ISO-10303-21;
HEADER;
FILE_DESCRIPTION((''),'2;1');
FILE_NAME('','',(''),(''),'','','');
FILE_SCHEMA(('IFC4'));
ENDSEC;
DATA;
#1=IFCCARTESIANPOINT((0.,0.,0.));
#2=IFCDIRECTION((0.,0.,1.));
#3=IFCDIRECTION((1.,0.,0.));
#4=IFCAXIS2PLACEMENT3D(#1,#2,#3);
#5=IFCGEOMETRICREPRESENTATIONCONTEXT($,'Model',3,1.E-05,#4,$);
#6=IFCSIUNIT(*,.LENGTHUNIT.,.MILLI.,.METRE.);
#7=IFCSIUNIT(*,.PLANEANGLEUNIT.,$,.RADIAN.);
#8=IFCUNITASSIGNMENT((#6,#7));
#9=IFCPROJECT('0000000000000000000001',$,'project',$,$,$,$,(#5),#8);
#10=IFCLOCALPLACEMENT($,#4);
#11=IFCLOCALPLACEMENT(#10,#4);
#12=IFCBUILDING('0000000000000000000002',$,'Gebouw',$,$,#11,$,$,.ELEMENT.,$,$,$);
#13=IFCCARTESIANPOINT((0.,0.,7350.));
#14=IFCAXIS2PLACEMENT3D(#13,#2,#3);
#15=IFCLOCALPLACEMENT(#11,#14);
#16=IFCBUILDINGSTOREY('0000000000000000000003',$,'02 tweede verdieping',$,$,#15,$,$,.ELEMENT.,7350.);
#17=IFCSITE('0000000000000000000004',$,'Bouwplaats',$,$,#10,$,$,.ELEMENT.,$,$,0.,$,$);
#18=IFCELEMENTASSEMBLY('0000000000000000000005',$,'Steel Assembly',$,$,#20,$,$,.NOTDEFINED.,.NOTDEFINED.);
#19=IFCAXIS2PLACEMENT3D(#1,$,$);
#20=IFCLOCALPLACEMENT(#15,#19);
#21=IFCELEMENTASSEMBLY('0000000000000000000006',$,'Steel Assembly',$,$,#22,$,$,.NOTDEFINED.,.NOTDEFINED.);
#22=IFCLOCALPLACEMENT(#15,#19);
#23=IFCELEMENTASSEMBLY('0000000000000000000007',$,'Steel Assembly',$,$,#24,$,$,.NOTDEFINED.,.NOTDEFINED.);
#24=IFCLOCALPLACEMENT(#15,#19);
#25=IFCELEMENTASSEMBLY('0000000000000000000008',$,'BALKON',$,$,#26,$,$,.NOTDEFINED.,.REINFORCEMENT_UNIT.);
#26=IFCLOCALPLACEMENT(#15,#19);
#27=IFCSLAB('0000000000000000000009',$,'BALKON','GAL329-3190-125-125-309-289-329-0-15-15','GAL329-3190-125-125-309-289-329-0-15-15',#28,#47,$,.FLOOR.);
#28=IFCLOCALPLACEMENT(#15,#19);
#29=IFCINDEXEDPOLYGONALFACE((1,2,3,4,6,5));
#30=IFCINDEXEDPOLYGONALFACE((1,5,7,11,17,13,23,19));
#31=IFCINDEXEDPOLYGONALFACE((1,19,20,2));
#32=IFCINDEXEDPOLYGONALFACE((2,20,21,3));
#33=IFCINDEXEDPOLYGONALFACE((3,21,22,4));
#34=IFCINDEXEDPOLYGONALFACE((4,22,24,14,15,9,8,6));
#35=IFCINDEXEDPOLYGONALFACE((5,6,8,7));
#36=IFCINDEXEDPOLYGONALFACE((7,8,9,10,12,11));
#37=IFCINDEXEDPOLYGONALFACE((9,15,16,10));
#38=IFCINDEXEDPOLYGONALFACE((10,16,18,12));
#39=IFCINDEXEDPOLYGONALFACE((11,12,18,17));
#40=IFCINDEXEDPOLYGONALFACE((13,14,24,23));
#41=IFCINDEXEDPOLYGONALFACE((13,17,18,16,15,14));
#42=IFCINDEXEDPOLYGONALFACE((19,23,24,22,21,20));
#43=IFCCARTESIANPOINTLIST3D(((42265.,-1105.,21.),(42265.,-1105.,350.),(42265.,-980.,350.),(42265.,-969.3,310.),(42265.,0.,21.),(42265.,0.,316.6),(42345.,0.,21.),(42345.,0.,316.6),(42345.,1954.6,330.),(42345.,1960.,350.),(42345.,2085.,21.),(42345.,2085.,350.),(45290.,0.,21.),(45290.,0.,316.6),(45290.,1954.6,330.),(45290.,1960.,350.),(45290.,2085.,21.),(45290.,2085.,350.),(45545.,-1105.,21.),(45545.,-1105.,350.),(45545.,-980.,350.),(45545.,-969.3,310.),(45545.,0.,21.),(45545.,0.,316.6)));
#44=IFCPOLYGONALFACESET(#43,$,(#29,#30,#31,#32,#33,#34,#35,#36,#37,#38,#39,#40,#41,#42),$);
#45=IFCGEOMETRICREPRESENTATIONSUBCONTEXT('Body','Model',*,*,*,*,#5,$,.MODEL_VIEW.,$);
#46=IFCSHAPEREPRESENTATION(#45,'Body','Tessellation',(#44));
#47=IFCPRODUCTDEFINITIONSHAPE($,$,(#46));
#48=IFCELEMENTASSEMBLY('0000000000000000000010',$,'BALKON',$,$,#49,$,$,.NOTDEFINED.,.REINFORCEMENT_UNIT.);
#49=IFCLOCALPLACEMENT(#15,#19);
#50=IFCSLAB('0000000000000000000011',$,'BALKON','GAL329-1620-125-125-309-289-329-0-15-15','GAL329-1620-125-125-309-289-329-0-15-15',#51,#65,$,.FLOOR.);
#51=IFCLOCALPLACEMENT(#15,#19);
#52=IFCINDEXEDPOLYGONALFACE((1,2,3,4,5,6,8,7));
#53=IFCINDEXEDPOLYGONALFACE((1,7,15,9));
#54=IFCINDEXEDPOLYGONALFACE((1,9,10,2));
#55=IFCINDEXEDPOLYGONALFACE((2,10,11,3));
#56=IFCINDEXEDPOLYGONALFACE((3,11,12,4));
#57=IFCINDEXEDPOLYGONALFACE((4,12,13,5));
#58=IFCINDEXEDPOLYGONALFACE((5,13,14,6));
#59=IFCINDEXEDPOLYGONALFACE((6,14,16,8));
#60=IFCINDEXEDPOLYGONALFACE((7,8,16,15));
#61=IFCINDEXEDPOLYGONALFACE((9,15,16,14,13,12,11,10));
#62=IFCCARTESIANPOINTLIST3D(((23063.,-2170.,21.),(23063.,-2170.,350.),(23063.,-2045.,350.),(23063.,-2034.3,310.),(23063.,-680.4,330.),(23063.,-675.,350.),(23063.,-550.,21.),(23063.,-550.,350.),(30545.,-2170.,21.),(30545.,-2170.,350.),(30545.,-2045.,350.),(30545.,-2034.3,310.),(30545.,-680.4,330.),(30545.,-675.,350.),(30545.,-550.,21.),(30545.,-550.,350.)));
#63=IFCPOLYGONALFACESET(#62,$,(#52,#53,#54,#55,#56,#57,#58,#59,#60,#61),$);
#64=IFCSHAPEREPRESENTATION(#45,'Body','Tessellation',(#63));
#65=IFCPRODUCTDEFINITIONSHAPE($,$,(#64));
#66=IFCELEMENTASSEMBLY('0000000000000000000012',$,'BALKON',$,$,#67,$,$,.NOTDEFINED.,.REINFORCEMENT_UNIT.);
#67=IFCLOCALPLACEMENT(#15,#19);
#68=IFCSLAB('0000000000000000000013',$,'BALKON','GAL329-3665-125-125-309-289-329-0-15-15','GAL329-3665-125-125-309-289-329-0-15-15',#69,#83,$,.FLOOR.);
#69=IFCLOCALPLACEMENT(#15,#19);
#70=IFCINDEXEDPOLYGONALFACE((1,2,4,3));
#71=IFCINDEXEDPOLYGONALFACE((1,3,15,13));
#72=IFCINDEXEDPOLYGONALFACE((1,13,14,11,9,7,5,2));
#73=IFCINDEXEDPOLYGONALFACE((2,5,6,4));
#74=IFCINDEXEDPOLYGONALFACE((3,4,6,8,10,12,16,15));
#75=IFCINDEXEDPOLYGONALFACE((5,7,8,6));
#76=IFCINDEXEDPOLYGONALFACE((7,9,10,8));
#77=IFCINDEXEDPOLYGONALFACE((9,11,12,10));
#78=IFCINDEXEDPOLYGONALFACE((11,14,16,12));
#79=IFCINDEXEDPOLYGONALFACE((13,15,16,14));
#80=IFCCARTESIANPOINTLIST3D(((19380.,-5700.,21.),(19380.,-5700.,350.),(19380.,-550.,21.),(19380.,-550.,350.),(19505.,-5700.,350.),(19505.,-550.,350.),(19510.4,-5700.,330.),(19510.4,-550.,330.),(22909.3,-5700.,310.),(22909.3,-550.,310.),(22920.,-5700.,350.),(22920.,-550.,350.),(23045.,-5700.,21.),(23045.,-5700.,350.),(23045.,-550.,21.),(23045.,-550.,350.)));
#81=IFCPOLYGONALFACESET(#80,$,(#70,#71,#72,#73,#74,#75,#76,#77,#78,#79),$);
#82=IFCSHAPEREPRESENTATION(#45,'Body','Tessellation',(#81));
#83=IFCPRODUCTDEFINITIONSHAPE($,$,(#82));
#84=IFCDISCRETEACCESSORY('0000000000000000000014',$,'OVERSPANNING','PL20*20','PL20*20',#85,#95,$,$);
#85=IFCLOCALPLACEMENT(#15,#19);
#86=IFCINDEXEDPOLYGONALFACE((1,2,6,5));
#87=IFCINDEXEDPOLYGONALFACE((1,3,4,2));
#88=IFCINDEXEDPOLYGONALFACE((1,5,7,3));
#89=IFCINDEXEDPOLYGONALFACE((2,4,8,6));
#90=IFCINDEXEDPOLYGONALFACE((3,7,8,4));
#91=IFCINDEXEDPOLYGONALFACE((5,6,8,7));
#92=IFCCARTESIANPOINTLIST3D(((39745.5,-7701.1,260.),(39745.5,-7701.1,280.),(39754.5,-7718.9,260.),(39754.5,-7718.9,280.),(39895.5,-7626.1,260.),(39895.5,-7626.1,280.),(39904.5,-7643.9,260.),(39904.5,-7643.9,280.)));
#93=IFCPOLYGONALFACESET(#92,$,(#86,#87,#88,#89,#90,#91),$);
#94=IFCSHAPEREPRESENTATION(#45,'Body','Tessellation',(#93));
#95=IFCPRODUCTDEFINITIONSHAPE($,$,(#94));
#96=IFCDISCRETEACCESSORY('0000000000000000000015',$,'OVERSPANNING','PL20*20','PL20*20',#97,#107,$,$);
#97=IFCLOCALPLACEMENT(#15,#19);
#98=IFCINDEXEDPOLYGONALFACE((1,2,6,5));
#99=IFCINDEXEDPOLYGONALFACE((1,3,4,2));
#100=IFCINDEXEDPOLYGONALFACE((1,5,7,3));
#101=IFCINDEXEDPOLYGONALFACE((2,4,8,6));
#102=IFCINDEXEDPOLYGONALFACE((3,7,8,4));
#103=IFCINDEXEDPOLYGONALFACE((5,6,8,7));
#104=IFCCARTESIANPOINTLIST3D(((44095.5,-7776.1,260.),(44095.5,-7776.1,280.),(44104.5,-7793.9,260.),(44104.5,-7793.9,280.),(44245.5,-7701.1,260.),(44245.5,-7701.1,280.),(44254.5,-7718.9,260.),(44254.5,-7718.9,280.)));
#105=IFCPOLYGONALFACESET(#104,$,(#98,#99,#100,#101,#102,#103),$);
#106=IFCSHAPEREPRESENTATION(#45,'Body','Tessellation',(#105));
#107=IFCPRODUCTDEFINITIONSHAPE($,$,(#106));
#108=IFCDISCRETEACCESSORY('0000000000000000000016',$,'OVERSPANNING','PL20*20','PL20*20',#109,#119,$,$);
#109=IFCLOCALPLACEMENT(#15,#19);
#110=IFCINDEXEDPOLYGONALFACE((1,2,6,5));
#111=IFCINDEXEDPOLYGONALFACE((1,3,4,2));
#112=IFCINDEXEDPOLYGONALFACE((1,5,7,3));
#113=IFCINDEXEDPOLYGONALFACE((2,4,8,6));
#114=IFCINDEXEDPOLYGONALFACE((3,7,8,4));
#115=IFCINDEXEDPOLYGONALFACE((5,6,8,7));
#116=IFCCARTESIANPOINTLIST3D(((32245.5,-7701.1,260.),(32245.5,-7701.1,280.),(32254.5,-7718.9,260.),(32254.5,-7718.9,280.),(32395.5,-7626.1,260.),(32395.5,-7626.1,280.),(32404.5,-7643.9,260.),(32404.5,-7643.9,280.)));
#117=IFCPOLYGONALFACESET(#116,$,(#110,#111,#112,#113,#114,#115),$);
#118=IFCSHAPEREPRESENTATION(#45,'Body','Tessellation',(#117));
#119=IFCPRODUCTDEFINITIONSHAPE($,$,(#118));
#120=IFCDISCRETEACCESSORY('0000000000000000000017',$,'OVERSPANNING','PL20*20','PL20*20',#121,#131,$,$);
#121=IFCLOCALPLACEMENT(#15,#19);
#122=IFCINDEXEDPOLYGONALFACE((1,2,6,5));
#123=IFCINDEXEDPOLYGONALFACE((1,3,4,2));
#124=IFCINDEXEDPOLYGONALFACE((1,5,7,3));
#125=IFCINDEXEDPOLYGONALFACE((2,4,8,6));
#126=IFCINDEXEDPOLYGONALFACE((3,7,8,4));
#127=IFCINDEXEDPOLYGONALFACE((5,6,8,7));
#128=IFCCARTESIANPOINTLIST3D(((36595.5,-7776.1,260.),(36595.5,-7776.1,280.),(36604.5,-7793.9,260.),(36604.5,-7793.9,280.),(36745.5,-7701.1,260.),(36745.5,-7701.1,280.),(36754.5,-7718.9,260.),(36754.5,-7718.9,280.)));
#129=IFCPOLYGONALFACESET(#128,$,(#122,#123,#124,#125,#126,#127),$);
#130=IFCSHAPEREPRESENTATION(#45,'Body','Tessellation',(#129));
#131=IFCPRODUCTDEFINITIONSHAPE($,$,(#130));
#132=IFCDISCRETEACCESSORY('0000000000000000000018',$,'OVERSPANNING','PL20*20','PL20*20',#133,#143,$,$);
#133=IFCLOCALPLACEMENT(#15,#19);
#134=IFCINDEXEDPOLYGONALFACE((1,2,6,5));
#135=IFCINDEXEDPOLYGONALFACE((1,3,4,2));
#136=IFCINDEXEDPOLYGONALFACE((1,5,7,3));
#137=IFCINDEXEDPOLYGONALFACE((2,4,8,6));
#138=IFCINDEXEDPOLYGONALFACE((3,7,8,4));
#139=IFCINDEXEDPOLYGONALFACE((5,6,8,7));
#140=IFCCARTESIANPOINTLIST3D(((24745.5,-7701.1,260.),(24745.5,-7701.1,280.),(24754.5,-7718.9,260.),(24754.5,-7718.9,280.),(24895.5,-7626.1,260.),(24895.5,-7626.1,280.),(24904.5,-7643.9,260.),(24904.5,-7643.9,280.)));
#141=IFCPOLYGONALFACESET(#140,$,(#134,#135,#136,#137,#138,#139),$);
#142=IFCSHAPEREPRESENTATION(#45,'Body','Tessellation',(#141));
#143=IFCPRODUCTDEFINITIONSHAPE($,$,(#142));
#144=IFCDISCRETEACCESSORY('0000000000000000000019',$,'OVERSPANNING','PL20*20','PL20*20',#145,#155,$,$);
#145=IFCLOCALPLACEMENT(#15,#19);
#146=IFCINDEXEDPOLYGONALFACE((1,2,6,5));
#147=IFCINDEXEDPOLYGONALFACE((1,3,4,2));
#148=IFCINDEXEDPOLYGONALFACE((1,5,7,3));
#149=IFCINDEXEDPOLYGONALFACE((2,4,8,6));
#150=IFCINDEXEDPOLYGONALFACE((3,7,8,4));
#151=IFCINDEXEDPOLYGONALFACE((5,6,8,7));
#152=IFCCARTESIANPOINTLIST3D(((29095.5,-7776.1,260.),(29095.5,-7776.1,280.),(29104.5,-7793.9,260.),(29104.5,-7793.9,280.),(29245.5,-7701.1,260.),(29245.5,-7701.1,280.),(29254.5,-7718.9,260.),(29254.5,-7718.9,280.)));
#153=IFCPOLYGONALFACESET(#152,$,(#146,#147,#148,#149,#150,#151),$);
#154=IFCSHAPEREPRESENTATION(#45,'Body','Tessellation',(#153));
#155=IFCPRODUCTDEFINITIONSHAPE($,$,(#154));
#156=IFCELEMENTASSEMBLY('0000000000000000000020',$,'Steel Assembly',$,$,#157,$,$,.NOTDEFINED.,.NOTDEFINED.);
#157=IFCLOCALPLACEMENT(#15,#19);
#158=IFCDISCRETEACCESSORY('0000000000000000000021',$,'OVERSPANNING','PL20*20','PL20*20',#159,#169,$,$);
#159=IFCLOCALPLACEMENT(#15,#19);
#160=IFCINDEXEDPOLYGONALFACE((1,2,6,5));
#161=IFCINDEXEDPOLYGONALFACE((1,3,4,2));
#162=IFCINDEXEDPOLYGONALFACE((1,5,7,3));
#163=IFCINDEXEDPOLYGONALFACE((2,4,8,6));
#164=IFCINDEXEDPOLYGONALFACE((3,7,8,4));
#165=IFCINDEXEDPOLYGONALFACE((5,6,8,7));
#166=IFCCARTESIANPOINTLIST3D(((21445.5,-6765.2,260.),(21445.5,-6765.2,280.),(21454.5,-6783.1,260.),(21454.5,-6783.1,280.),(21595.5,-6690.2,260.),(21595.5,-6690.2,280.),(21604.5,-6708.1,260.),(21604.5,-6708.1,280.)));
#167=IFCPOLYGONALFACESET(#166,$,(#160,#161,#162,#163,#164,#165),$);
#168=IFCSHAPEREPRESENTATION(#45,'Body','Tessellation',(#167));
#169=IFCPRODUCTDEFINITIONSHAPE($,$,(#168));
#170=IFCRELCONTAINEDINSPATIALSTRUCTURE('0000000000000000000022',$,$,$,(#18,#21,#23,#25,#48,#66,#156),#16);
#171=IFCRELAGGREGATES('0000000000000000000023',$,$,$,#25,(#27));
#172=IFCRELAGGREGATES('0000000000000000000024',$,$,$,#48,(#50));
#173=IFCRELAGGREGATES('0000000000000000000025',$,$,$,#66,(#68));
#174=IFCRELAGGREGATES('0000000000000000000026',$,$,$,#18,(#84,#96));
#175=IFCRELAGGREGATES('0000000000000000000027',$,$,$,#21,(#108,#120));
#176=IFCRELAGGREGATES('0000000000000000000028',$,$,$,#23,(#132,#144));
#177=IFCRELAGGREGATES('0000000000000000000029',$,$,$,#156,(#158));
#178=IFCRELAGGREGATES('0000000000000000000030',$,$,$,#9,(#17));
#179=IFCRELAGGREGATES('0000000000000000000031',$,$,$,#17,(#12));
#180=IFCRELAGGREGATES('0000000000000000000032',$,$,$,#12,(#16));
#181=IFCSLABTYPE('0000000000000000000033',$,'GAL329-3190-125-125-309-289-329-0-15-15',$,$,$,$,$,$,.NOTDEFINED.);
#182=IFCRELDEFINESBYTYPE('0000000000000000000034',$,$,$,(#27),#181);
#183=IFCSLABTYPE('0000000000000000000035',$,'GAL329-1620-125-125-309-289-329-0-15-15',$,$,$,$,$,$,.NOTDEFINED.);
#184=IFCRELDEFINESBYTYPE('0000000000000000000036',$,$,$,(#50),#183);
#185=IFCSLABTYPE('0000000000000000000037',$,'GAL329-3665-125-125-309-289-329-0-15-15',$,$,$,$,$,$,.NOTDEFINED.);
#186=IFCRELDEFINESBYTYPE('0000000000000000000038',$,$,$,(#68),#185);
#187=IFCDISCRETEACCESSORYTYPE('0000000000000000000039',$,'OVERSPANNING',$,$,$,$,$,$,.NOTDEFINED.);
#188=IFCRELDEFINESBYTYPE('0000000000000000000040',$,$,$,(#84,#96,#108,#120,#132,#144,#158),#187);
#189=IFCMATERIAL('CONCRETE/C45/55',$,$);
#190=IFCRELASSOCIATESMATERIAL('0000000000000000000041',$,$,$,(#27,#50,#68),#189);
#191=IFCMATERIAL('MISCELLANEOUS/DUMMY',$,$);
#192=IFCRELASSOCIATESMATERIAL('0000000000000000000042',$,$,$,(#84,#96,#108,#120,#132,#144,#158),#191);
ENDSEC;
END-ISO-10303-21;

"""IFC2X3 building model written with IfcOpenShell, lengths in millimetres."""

from ifc_helpers import new_model, si_unit, frame, origin_with_axes, origin_2d_with_axis, place, context, subcontext, project, spatial, polyline, rectangle, outline, extrude, boolean, material, type_object, element, aggregate, save


model = new_model("IFC2X3")

# Units and contexts
model_context = context("Model", 3, precision=1e-05, world=origin_with_axes())
body_context = subcontext(model_context, "Body", "Model", "MODEL_VIEW")
ifc_project = project(units=[si_unit("LENGTHUNIT", "METRE", prefix="MILLI"), si_unit("PLANEANGLEUNIT", "RADIAN")], contexts=[model_context])

# Site, building, storey
site_placement = place(None, origin_with_axes())
site = spatial("IfcSite", under=ifc_project, at=site_placement, Name="Bouwplaats", CompositionType="ELEMENT", RefElevation=0.0)
building_placement = place(site_placement, origin_with_axes())
building = spatial("IfcBuilding", under=site, at=building_placement, Name="Gebouw", CompositionType="ELEMENT")
storey_placement = place(building_placement, frame((0.0, 0.0, 7350.0), z_axis=(0.0, 0.0, 1.0), x_axis=(1.0, 0.0, 0.0)))
storey = spatial("IfcBuildingStorey", under=building, at=storey_placement, Name="02 tweede verdieping", CompositionType="ELEMENT", Elevation=7350.0)

# Element assemblies
ifc_material_1 = material(Name="MISCELLANEOUS/DUMMY")
assembly_1_placement = place(storey_placement, origin_with_axes())
assembly_1 = element("IfcElementAssembly", 1, at=assembly_1_placement, inside=storey, Name="Steel Assembly", AssemblyPlace="NOTDEFINED", PredefinedType="NOTDEFINED")
assembly_2_placement = place(storey_placement, origin_with_axes())
assembly_2 = element("IfcElementAssembly", 2, at=assembly_2_placement, inside=storey, Name="Steel Assembly", AssemblyPlace="NOTDEFINED", PredefinedType="NOTDEFINED")
assembly_3_placement = place(storey_placement, origin_with_axes())
assembly_3 = element("IfcElementAssembly", 3, at=assembly_3_placement, inside=storey, Name="Steel Assembly", AssemblyPlace="NOTDEFINED", PredefinedType="NOTDEFINED")

# Element assemblies, slabs
ifc_material_2 = material(Name="CONCRETE/C45/55")
slab_type_1 = type_object("IfcSlabType", Name="GAL329-3190-125-125-309-289-329-0-15-15", PredefinedType="NOTDEFINED")
assembly_4_placement = place(storey_placement, origin_with_axes())
assembly_4 = element("IfcElementAssembly", 4, at=assembly_4_placement, inside=storey, Name="BALKON", AssemblyPlace="NOTDEFINED", PredefinedType="REINFORCEMENT_UNIT")
slab_1_placement = place(assembly_4_placement, frame((42265.0, 490.0, 185.5), z_axis=(0.0, 0.0, 1.0), x_axis=(1.0, 0.0, 0.0)))
slab_1 = element("IfcSlab", 5, at=slab_1_placement, type_object=slab_type_1, material=ifc_material_2, Name="BALKON", Description="GAL329-3190-125-125-309-289-329-0-15-15", ObjectType="GAL329-3190-125-125-309-289-329-0-15-15", PredefinedType="FLOOR", context=body_context, shape_type="CSG", body=[
    boolean("DIFFERENCE", boolean("DIFFERENCE", extrude(outline(polyline([(1595.0, -164.5), (-1595.0, -164.5), (-1595.0, 164.5), (-1470.0, 164.5), (-1464.6, 144.5), (1459.3, 124.5), (1470.0, 164.5), (1595.0, 164.5), (1595.0, -164.5)])), frame((3280.0, 0.0, 0.0), z_axis=(-1.0, 0.0, 0.0), x_axis=(0.0, -1.0, 0.0)), (0.0, 0.0, 1.0), 3280.0), extrude(rectangle(XDim=350.0, YDim=255.0, at=origin_2d_with_axis()), frame((3152.5, 1595.0, -10.5), z_axis=(0.0, -1.0, 0.0), x_axis=(0.0, 0.0, -1.0)), (0.0, 0.0, 1.0), 2085.0)), extrude(rectangle(XDim=350.0, YDim=80.0, at=origin_2d_with_axis()), frame((40.0, -490.0, -10.5), z_axis=(0.0, 1.0, 0.0), x_axis=(0.0, 0.0, -1.0)), (0.0, 0.0, 1.0), 2085.0)),
])
aggregate(assembly_4, [slab_1])
assembly_5_placement = place(storey_placement, origin_with_axes())
assembly_5 = element("IfcElementAssembly", 6, at=assembly_5_placement, inside=storey, Name="BALKON", AssemblyPlace="NOTDEFINED", PredefinedType="REINFORCEMENT_UNIT")
slab_type_2 = type_object("IfcSlabType", Name="GAL329-1620-125-125-309-289-329-0-15-15", PredefinedType="NOTDEFINED")
slab_2_placement = place(assembly_5_placement, frame((23063.0, -1360.0, 185.5), z_axis=(0.0, 0.0, 1.0), x_axis=(1.0, 0.0, 0.0)))
slab_2 = element("IfcSlab", 7, at=slab_2_placement, type_object=slab_type_2, material=ifc_material_2, Name="BALKON", Description="GAL329-1620-125-125-309-289-329-0-15-15", ObjectType="GAL329-1620-125-125-309-289-329-0-15-15", PredefinedType="FLOOR", context=body_context, shape_type="SweptSolid", body=[
    extrude(outline(polyline([(810.0, -164.5), (-810.0, -164.5), (-810.0, 164.5), (-685.0, 164.5), (-679.6, 144.5), (674.3, 124.5), (685.0, 164.5), (810.0, 164.5), (810.0, -164.5)])), frame((7482.0, 0.0, 0.0), z_axis=(-1.0, 0.0, 0.0), x_axis=(0.0, -1.0, 0.0)), (0.0, 0.0, 1.0), 7482.0),
])
aggregate(assembly_5, [slab_2])
assembly_6_placement = place(storey_placement, origin_with_axes())
assembly_6 = element("IfcElementAssembly", 8, at=assembly_6_placement, inside=storey, Name="BALKON", AssemblyPlace="NOTDEFINED", PredefinedType="REINFORCEMENT_UNIT")
slab_type_3 = type_object("IfcSlabType", Name="GAL329-3665-125-125-309-289-329-0-15-15", PredefinedType="NOTDEFINED")
slab_3_placement = place(assembly_6_placement, frame((21212.5, -5700.0, 185.5), z_axis=(0.0, 0.0, 1.0), x_axis=(0.0, 1.0, 0.0)))
slab_3 = element("IfcSlab", 9, at=slab_3_placement, type_object=slab_type_3, material=ifc_material_2, Name="BALKON", Description="GAL329-3665-125-125-309-289-329-0-15-15", ObjectType="GAL329-3665-125-125-309-289-329-0-15-15", PredefinedType="FLOOR", context=body_context, shape_type="SweptSolid", body=[
    extrude(outline(polyline([(1696.8, 124.5), (1707.5, 164.5), (1832.5, 164.5), (1832.5, -164.5), (-1832.5, -164.5), (-1832.5, 164.5), (-1707.5, 164.5), (-1702.1, 144.5), (1696.8, 124.5)])), frame((5150.0, 0.0, 0.0), z_axis=(-1.0, 0.0, 0.0), x_axis=(0.0, -1.0, 0.0)), (0.0, 0.0, 1.0), 5150.0),
])
aggregate(assembly_6, [slab_3])

# Discrete accessories
discrete_accessory_type = type_object("IfcDiscreteAccessoryType", Name="OVERSPANNING")
discrete_accessory_1_placement = place(assembly_1_placement, frame((39900.0, -7635.0, 270.0), z_axis=(0.447214, -0.894427, 0.0), x_axis=(-0.894427, -0.447214, 0.0)))
discrete_accessory_1 = element("IfcDiscreteAccessory", 10, at=discrete_accessory_1_placement, type_object=discrete_accessory_type, material=ifc_material_1, Name="OVERSPANNING", Description="PL20*20", ObjectType="PL20*20", context=body_context, shape_type="SweptSolid", body=[
    extrude(rectangle(XDim=20.0, YDim=20.0, at=origin_2d_with_axis()), frame((167.7, 0.0, 0.0), z_axis=(-1.0, 0.0, 0.0), x_axis=(0.0, -1.0, 0.0)), (0.0, 0.0, 1.0), 167.7),
])
discrete_accessory_2_placement = place(assembly_1_placement, frame((44100.0, -7785.0, 270.0), z_axis=(-0.447214, 0.894427, 0.0), x_axis=(0.894427, 0.447214, 0.0)))
discrete_accessory_2 = element("IfcDiscreteAccessory", 11, at=discrete_accessory_2_placement, type_object=discrete_accessory_type, material=ifc_material_1, Name="OVERSPANNING", Description="PL20*20", ObjectType="PL20*20", context=body_context, shape_type="SweptSolid", body=[
    extrude(rectangle(XDim=20.0, YDim=20.0, at=origin_2d_with_axis()), frame((167.7, 0.0, 0.0), z_axis=(-1.0, 0.0, 0.0), x_axis=(0.0, -1.0, 0.0)), (0.0, 0.0, 1.0), 167.7),
])
aggregate(assembly_1, [discrete_accessory_1, discrete_accessory_2])
discrete_accessory_3_placement = place(assembly_2_placement, frame((32400.0, -7635.0, 270.0), z_axis=(0.447214, -0.894427, 0.0), x_axis=(-0.894427, -0.447214, 0.0)))
discrete_accessory_3 = element("IfcDiscreteAccessory", 12, at=discrete_accessory_3_placement, type_object=discrete_accessory_type, material=ifc_material_1, Name="OVERSPANNING", Description="PL20*20", ObjectType="PL20*20", context=body_context, shape_type="SweptSolid", body=[
    extrude(rectangle(XDim=20.0, YDim=20.0, at=origin_2d_with_axis()), frame((167.7, 0.0, 0.0), z_axis=(-1.0, 0.0, 0.0), x_axis=(0.0, -1.0, 0.0)), (0.0, 0.0, 1.0), 167.7),
])
discrete_accessory_4_placement = place(assembly_2_placement, frame((36600.0, -7785.0, 270.0), z_axis=(-0.447214, 0.894427, 0.0), x_axis=(0.894427, 0.447214, 0.0)))
discrete_accessory_4 = element("IfcDiscreteAccessory", 13, at=discrete_accessory_4_placement, type_object=discrete_accessory_type, material=ifc_material_1, Name="OVERSPANNING", Description="PL20*20", ObjectType="PL20*20", context=body_context, shape_type="SweptSolid", body=[
    extrude(rectangle(XDim=20.0, YDim=20.0, at=origin_2d_with_axis()), frame((167.7, 0.0, 0.0), z_axis=(-1.0, 0.0, 0.0), x_axis=(0.0, -1.0, 0.0)), (0.0, 0.0, 1.0), 167.7),
])
aggregate(assembly_2, [discrete_accessory_3, discrete_accessory_4])
discrete_accessory_5_placement = place(assembly_3_placement, frame((24900.0, -7635.0, 270.0), z_axis=(0.447214, -0.894427, 0.0), x_axis=(-0.894427, -0.447214, 0.0)))
discrete_accessory_5 = element("IfcDiscreteAccessory", 14, at=discrete_accessory_5_placement, type_object=discrete_accessory_type, material=ifc_material_1, Name="OVERSPANNING", Description="PL20*20", ObjectType="PL20*20", context=body_context, shape_type="SweptSolid", body=[
    extrude(rectangle(XDim=20.0, YDim=20.0, at=origin_2d_with_axis()), frame((167.7, 0.0, 0.0), z_axis=(-1.0, 0.0, 0.0), x_axis=(0.0, -1.0, 0.0)), (0.0, 0.0, 1.0), 167.7),
])
discrete_accessory_6_placement = place(assembly_3_placement, frame((29100.0, -7785.0, 270.0), z_axis=(-0.447214, 0.894427, 0.0), x_axis=(0.894427, 0.447214, 0.0)))
discrete_accessory_6 = element("IfcDiscreteAccessory", 15, at=discrete_accessory_6_placement, type_object=discrete_accessory_type, material=ifc_material_1, Name="OVERSPANNING", Description="PL20*20", ObjectType="PL20*20", context=body_context, shape_type="SweptSolid", body=[
    extrude(rectangle(XDim=20.0, YDim=20.0, at=origin_2d_with_axis()), frame((167.7, 0.0, 0.0), z_axis=(-1.0, 0.0, 0.0), x_axis=(0.0, -1.0, 0.0)), (0.0, 0.0, 1.0), 167.7),
])
aggregate(assembly_3, [discrete_accessory_5, discrete_accessory_6])

# Element assembly, discrete accessory
assembly_7_placement = place(storey_placement, origin_with_axes())
assembly_7 = element("IfcElementAssembly", 16, at=assembly_7_placement, inside=storey, Name="Steel Assembly", AssemblyPlace="NOTDEFINED", PredefinedType="NOTDEFINED")
discrete_accessory_7_placement = place(assembly_7_placement, frame((21450.0, -6774.1, 270.0), z_axis=(-0.447214, 0.894427, 0.0), x_axis=(0.894427, 0.447214, 0.0)))
discrete_accessory_7 = element("IfcDiscreteAccessory", 17, at=discrete_accessory_7_placement, type_object=discrete_accessory_type, material=ifc_material_1, Name="OVERSPANNING", Description="PL20*20", ObjectType="PL20*20", context=body_context, shape_type="SweptSolid", body=[
    extrude(rectangle(XDim=20.0, YDim=20.0, at=origin_2d_with_axis()), frame((167.7, 0.0, 0.0), z_axis=(-1.0, 0.0, 0.0), x_axis=(0.0, -1.0, 0.0)), (0.0, 0.0, 1.0), 167.7),
])
aggregate(assembly_7, [discrete_accessory_7])

save(model, "model.ifc")
